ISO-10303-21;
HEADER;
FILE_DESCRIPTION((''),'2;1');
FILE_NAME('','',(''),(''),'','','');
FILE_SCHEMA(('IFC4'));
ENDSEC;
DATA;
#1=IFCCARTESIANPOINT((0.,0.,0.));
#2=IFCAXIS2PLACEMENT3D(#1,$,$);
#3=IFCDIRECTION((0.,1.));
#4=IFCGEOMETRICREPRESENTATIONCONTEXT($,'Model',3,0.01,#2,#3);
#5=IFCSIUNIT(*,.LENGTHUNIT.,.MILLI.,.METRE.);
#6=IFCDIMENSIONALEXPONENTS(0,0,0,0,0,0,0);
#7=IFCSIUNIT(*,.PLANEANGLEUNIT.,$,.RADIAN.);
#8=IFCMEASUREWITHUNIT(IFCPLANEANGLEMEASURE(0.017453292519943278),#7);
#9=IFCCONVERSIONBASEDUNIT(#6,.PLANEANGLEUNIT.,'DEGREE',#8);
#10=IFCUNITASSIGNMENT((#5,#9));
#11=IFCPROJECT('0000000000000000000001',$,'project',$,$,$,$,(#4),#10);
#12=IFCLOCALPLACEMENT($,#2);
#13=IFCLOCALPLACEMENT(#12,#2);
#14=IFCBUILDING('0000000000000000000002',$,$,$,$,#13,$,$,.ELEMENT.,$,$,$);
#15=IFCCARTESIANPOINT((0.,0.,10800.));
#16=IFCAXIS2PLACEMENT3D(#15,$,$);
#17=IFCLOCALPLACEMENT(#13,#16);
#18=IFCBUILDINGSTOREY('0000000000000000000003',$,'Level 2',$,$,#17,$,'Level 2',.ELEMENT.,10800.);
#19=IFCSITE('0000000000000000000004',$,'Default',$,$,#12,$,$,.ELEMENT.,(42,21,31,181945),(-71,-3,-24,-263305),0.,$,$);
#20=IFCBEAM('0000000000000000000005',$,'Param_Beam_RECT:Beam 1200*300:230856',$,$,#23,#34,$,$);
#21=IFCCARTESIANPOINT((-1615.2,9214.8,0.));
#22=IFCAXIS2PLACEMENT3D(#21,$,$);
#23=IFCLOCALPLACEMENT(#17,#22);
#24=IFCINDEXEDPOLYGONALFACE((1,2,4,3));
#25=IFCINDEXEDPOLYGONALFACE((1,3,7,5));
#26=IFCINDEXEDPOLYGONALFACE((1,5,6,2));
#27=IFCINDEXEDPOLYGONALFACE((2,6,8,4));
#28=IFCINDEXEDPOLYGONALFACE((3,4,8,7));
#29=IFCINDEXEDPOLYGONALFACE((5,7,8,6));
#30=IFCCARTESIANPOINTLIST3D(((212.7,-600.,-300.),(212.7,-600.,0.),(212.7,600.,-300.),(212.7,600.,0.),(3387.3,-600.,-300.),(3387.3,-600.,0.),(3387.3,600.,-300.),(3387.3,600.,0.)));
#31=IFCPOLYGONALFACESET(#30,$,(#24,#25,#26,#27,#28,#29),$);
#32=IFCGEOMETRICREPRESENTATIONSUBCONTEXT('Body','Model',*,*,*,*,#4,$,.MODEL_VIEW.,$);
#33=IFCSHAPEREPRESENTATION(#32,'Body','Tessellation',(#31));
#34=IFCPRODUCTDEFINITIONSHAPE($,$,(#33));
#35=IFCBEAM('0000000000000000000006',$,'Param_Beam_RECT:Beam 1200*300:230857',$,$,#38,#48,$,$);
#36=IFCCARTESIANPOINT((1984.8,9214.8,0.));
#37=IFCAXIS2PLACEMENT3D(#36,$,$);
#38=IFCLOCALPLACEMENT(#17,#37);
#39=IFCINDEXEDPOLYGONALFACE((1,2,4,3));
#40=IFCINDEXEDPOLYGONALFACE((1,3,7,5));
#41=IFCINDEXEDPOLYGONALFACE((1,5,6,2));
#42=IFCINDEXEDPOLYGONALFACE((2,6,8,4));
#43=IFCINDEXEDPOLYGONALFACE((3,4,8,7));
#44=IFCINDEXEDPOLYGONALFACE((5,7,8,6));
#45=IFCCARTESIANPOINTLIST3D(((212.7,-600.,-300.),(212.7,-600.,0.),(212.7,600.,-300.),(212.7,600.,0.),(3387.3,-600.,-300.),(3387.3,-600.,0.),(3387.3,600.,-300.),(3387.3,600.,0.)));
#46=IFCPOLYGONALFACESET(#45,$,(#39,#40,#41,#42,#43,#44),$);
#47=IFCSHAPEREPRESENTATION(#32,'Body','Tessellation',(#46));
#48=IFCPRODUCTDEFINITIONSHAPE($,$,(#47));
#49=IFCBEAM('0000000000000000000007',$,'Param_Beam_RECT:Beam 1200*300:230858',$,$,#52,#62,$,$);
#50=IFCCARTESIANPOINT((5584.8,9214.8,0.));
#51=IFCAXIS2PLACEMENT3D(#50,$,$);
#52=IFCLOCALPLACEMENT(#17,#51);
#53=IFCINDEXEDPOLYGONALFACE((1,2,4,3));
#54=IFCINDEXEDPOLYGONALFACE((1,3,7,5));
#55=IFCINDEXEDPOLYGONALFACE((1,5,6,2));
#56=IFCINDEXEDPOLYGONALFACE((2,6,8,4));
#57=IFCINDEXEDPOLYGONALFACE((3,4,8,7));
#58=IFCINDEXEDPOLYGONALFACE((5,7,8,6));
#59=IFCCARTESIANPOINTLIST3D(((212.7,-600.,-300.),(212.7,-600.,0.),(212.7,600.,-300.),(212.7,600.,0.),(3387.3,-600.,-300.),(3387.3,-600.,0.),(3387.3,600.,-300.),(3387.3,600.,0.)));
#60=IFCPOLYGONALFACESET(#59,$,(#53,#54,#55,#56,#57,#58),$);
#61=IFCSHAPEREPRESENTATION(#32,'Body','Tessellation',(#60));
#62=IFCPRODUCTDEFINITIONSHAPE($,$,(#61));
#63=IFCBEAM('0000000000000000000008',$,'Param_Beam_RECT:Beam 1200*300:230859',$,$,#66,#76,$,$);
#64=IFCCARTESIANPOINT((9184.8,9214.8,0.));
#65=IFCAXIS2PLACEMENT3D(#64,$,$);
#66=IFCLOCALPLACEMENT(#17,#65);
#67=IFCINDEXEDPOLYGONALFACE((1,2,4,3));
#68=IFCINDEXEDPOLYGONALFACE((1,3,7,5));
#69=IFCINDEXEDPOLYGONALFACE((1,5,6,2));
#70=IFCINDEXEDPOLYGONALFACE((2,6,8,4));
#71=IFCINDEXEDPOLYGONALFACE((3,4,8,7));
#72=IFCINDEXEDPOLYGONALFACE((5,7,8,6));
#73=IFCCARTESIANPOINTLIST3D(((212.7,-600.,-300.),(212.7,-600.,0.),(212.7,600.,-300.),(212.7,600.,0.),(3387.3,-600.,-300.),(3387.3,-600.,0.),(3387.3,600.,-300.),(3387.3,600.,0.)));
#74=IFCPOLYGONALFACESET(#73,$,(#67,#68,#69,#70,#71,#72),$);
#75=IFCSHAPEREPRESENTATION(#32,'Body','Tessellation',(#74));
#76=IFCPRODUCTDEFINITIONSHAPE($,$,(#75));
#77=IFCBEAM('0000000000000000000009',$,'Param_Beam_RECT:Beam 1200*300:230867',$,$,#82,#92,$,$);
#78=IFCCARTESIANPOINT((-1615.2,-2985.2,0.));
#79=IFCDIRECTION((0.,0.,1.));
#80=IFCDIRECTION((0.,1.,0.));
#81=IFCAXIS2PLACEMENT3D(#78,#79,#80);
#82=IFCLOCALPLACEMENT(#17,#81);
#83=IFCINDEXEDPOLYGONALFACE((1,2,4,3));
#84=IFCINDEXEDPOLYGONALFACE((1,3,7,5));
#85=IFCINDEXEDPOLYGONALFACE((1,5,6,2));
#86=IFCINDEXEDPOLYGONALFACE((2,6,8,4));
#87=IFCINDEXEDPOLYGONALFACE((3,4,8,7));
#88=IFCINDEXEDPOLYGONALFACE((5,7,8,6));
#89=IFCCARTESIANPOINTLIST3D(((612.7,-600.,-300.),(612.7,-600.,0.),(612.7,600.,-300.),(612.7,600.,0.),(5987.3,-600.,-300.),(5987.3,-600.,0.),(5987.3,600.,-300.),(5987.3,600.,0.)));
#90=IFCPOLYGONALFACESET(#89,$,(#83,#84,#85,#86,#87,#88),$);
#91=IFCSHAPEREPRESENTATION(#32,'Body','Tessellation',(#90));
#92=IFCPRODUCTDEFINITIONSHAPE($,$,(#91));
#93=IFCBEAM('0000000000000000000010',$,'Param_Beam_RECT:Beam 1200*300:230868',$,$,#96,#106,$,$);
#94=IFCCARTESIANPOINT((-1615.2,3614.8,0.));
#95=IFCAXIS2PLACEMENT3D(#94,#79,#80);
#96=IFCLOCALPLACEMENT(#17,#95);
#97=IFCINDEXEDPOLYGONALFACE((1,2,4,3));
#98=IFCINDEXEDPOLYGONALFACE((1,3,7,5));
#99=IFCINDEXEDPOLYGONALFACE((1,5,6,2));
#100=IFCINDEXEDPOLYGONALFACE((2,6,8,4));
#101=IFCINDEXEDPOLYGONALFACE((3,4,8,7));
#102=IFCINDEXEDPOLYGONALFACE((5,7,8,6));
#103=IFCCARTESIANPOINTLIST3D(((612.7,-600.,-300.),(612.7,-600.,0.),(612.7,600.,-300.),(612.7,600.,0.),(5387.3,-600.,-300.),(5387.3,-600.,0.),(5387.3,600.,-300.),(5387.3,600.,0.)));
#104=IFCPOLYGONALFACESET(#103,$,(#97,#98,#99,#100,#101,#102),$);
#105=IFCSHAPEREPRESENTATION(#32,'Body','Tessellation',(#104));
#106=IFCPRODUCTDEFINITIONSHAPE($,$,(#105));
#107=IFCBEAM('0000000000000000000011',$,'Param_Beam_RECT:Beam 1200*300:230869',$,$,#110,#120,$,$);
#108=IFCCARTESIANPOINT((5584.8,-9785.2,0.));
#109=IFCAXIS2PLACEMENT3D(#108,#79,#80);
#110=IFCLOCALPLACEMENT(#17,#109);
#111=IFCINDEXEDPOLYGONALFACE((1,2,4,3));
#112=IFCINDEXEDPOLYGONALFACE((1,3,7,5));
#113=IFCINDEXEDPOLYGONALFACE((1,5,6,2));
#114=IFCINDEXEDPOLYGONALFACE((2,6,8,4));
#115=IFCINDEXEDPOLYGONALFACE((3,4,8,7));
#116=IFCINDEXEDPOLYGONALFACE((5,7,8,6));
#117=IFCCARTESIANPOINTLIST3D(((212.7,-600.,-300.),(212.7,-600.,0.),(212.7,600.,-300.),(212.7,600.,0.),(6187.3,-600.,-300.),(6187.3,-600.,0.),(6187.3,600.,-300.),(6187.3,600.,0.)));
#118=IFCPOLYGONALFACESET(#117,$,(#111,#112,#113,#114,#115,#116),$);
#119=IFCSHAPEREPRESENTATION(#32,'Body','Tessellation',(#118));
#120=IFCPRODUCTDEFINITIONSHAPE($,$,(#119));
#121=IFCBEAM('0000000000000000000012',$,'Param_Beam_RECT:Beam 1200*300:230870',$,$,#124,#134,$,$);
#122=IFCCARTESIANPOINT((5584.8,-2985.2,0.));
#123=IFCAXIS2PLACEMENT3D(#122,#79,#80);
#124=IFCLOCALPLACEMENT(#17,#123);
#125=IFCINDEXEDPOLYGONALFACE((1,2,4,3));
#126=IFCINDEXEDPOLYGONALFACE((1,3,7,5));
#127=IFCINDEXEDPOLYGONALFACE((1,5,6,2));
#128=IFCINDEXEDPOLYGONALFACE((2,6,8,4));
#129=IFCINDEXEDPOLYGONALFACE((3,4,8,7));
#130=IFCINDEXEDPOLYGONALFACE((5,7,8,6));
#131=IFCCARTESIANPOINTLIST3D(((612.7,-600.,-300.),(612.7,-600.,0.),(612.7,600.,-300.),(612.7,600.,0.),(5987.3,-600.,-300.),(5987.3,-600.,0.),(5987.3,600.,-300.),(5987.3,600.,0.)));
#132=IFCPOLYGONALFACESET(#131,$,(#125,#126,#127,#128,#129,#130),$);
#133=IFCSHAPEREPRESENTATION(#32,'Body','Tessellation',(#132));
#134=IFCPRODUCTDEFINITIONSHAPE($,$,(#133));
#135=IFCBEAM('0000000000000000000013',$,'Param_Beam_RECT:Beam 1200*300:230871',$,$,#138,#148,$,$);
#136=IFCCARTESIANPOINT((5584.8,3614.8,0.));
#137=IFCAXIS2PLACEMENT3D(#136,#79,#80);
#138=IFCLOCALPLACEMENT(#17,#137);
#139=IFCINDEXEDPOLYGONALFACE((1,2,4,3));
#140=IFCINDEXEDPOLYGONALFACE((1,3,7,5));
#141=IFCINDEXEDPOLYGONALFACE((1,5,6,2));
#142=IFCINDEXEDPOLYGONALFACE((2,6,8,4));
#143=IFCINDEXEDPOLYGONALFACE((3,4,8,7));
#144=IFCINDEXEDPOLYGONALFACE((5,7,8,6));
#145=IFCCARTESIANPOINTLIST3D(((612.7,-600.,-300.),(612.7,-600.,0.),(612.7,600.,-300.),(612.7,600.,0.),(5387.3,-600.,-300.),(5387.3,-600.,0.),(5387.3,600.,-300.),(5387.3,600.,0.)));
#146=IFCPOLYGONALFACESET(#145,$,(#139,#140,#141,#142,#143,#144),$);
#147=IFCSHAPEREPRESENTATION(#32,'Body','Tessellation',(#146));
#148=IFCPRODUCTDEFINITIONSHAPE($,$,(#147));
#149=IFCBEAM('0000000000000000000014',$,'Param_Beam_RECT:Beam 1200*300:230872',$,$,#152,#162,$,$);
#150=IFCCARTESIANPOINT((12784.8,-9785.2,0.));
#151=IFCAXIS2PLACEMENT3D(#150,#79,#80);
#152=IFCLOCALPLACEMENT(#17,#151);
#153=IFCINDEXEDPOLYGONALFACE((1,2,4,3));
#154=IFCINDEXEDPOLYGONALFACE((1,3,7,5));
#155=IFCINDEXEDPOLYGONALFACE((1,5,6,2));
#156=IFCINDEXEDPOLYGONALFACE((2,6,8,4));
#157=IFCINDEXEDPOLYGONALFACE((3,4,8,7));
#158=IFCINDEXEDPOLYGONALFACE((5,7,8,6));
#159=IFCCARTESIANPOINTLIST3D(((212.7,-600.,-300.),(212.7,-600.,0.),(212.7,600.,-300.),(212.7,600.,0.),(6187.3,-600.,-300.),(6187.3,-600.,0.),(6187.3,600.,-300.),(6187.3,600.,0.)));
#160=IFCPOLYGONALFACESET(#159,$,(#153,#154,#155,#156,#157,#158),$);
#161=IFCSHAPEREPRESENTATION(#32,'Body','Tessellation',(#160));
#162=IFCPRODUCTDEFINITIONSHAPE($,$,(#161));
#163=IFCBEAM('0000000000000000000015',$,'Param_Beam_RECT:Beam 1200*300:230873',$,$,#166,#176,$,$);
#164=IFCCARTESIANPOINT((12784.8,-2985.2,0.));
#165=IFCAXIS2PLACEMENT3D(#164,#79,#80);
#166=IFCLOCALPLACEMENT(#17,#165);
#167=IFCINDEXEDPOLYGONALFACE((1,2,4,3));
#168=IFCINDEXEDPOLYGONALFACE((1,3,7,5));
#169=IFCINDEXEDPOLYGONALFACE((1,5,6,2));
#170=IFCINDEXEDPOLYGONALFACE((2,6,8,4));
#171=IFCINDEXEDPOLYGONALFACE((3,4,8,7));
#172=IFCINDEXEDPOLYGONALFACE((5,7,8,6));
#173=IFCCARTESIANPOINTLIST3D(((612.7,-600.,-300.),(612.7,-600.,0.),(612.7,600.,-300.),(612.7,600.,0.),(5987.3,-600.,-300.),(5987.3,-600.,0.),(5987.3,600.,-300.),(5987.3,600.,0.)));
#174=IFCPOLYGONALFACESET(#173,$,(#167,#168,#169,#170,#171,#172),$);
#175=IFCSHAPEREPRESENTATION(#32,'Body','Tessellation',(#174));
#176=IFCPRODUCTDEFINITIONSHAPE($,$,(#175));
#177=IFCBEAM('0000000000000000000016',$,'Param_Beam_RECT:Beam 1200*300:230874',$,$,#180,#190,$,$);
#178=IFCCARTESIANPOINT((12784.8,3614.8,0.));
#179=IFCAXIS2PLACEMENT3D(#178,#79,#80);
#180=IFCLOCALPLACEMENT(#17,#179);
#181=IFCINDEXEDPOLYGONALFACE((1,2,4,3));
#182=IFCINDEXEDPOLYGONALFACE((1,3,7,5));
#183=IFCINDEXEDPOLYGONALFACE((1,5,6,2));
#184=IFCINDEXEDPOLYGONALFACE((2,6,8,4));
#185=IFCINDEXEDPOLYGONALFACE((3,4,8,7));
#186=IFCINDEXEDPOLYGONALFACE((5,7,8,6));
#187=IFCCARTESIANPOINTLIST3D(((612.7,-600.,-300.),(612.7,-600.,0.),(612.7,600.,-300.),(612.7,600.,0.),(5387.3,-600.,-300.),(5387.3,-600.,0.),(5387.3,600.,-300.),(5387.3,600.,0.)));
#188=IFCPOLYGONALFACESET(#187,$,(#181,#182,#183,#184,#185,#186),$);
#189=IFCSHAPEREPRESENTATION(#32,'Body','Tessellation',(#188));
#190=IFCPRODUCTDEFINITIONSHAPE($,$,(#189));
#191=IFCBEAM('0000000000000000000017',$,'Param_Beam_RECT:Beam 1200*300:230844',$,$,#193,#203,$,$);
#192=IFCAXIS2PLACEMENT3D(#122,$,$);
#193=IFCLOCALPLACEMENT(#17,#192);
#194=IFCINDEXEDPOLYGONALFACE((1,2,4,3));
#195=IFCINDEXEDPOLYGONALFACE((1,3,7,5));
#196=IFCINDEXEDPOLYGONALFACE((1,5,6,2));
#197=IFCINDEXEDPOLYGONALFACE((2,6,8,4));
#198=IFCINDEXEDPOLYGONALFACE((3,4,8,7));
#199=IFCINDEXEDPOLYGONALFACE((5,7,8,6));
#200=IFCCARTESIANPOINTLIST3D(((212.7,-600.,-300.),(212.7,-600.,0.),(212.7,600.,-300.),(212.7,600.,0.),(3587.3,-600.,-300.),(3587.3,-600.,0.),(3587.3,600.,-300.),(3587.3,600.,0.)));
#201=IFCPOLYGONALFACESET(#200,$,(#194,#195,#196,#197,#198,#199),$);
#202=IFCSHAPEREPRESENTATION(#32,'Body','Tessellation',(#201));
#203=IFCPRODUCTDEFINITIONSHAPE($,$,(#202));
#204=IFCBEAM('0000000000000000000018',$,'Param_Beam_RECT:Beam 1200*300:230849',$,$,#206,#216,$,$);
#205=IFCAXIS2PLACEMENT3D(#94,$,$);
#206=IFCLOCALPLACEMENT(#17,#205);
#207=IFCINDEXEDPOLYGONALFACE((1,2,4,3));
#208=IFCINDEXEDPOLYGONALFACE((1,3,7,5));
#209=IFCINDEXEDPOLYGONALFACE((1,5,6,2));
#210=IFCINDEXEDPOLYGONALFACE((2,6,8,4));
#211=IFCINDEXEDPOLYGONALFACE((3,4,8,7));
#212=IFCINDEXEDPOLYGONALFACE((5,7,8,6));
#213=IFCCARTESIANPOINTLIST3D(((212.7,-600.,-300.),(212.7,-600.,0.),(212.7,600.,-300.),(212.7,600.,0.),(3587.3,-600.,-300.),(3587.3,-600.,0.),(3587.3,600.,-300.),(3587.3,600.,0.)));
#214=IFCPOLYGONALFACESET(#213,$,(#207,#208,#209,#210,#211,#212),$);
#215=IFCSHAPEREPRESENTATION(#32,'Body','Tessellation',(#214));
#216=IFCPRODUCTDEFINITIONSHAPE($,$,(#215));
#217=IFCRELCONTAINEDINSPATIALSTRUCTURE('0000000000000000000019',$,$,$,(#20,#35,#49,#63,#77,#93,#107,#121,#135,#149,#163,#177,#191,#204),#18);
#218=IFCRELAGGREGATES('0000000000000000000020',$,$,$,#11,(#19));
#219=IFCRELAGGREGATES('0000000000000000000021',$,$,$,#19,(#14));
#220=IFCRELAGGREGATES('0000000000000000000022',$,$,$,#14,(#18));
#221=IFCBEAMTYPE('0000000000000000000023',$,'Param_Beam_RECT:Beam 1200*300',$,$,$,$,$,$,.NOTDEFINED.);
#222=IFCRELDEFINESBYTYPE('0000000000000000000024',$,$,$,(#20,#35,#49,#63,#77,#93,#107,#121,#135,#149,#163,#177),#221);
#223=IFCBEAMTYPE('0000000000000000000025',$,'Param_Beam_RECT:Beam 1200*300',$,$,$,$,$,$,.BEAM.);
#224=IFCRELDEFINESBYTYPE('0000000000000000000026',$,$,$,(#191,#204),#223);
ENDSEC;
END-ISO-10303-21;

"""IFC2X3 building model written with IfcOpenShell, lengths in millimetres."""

from ifc_helpers import new_model, entity, si_unit, converted_unit, direction, frame, frame_2d, origin, origin_2d_with_axis, place, context, subcontext, project, spatial, rectangle, extrude, type_object, element, save


model = new_model("IFC2X3")

# Units and contexts
model_context = context("Model", 3, precision=0.01, world=origin(), true_north=direction((0.0, 1.0)))
body_context = subcontext(model_context, "Body", "Model", "MODEL_VIEW")
ifc_project = project(units=[si_unit("LENGTHUNIT", "METRE", prefix="MILLI"), converted_unit("PLANEANGLEUNIT", "DEGREE", entity("IfcPlaneAngleMeasure", 0.017453292519943278), si_unit("PLANEANGLEUNIT", "RADIAN"), dimensions=[0, 0, 0, 0, 0, 0, 0])], contexts=[model_context])

# Site, building, storey
site_placement = place(None, origin())
site = spatial("IfcSite", under=ifc_project, at=site_placement, Name="Default", CompositionType="ELEMENT", RefLatitude=(42, 21, 31, 181945), RefLongitude=(-71, -3, -24, -263305), RefElevation=0.0)
building_placement = place(site_placement, origin())
building = spatial("IfcBuilding", under=site, at=building_placement, CompositionType="ELEMENT")
storey_placement = place(building_placement, frame((0.0, 0.0, 10800.0)))
storey = spatial("IfcBuildingStorey", under=building, at=storey_placement, Name="Level 2", LongName="Level 2", CompositionType="ELEMENT", Elevation=10800.0)

# Beams
beam_type_1 = type_object("IfcBeamType", Name="Param_Beam_RECT:Beam 1200*300", PredefinedType="NOTDEFINED")
beam_1_placement = place(storey_placement, frame((-1615.2, 9214.8, 0.0)))
element("IfcBeam", 1, at=beam_1_placement, inside=storey, type_object=beam_type_1, Name="Param_Beam_RECT:Beam 1200*300:230856", context=body_context, shape_type="SweptSolid", body=[
    extrude(rectangle(XDim=300.0, YDim=1200.0, at=frame_2d((0.0, 0.0), x_axis=(1.0, 0.0))), frame((212.7, 0.0, -150.0), z_axis=(1.0, 0.0, 0.0), x_axis=(0.0, 0.0, -1.0)), (0.0, 0.0, 1.0), 3174.6),
])
beam_2_placement = place(storey_placement, frame((1984.8, 9214.8, 0.0)))
element("IfcBeam", 2, at=beam_2_placement, inside=storey, type_object=beam_type_1, Name="Param_Beam_RECT:Beam 1200*300:230857", context=body_context, shape_type="SweptSolid", body=[
    extrude(rectangle(XDim=300.0, YDim=1200.0, at=origin_2d_with_axis()), frame((212.7, 0.0, -150.0), z_axis=(1.0, 0.0, 0.0), x_axis=(0.0, 0.0, -1.0)), (0.0, 0.0, 1.0), 3174.6),
])
for number, where, name in (
    (3, (5584.8, 9214.8, 0.0), "Param_Beam_RECT:Beam 1200*300:230858"),
    (4, (9184.8, 9214.8, 0.0), "Param_Beam_RECT:Beam 1200*300:230859"),
):
    element("IfcBeam", number, at=place(storey_placement, frame(where)), inside=storey, type_object=beam_type_1, Name=name, context=body_context, shape_type="SweptSolid", body=[
        extrude(rectangle(XDim=300.0, YDim=1200.0, at=frame_2d((0.0, 0.0), x_axis=(1.0, 0.0))), frame((212.7, 0.0, -150.0), z_axis=(1.0, 0.0, 0.0), x_axis=(0.0, 0.0, -1.0)), (0.0, 0.0, 1.0), 3174.6),
    ])
beam_3_placement = place(storey_placement, frame((-1615.2, -2985.2, 0.0), z_axis=(0.0, 0.0, 1.0), x_axis=(0.0, 1.0, 0.0)))
element("IfcBeam", 5, at=beam_3_placement, inside=storey, type_object=beam_type_1, Name="Param_Beam_RECT:Beam 1200*300:230867", context=body_context, shape_type="SweptSolid", body=[
    extrude(rectangle(XDim=300.0, YDim=1200.0, at=frame_2d((0.0, 0.0), x_axis=(1.0, 0.0))), frame((612.7, 0.0, -150.0), z_axis=(1.0, 0.0, 0.0), x_axis=(0.0, 0.0, -1.0)), (0.0, 0.0, 1.0), 5374.6),
])
beam_4_placement = place(storey_placement, frame((-1615.2, 3614.8, 0.0), z_axis=(0.0, 0.0, 1.0), x_axis=(0.0, 1.0, 0.0)))
element("IfcBeam", 6, at=beam_4_placement, inside=storey, type_object=beam_type_1, Name="Param_Beam_RECT:Beam 1200*300:230868", context=body_context, shape_type="SweptSolid", body=[
    extrude(rectangle(XDim=300.0, YDim=1200.0, at=frame_2d((0.0, 0.0), x_axis=(1.0, 0.0))), frame((612.7, 0.0, -150.0), z_axis=(1.0, 0.0, 0.0), x_axis=(0.0, 0.0, -1.0)), (0.0, 0.0, 1.0), 4774.6),
])
beam_5_placement = place(storey_placement, frame((5584.8, -9785.2, 0.0), z_axis=(0.0, 0.0, 1.0), x_axis=(0.0, 1.0, 0.0)))
element("IfcBeam", 7, at=beam_5_placement, inside=storey, type_object=beam_type_1, Name="Param_Beam_RECT:Beam 1200*300:230869", context=body_context, shape_type="SweptSolid", body=[
    extrude(rectangle(XDim=300.0, YDim=1200.0, at=frame_2d((0.0, 0.0), x_axis=(1.0, 0.0))), frame((212.7, 0.0, -150.0), z_axis=(1.0, 0.0, 0.0), x_axis=(0.0, 0.0, -1.0)), (0.0, 0.0, 1.0), 5974.6),
])
beam_6_placement = place(storey_placement, frame((5584.8, -2985.2, 0.0), z_axis=(0.0, 0.0, 1.0), x_axis=(0.0, 1.0, 0.0)))
element("IfcBeam", 8, at=beam_6_placement, inside=storey, type_object=beam_type_1, Name="Param_Beam_RECT:Beam 1200*300:230870", context=body_context, shape_type="SweptSolid", body=[
    extrude(rectangle(XDim=300.0, YDim=1200.0, at=frame_2d((0.0, 0.0), x_axis=(1.0, 0.0))), frame((612.7, 0.0, -150.0), z_axis=(1.0, 0.0, 0.0), x_axis=(0.0, 0.0, -1.0)), (0.0, 0.0, 1.0), 5374.6),
])
beam_7_placement = place(storey_placement, frame((5584.8, 3614.8, 0.0), z_axis=(0.0, 0.0, 1.0), x_axis=(0.0, 1.0, 0.0)))
element("IfcBeam", 9, at=beam_7_placement, inside=storey, type_object=beam_type_1, Name="Param_Beam_RECT:Beam 1200*300:230871", context=body_context, shape_type="SweptSolid", body=[
    extrude(rectangle(XDim=300.0, YDim=1200.0, at=frame_2d((0.0, 0.0), x_axis=(1.0, 0.0))), frame((612.7, 0.0, -150.0), z_axis=(1.0, 0.0, 0.0), x_axis=(0.0, 0.0, -1.0)), (0.0, 0.0, 1.0), 4774.6),
])
beam_8_placement = place(storey_placement, frame((12784.8, -9785.2, 0.0), z_axis=(0.0, 0.0, 1.0), x_axis=(0.0, 1.0, 0.0)))
element("IfcBeam", 10, at=beam_8_placement, inside=storey, type_object=beam_type_1, Name="Param_Beam_RECT:Beam 1200*300:230872", context=body_context, shape_type="SweptSolid", body=[
    extrude(rectangle(XDim=300.0, YDim=1200.0, at=origin_2d_with_axis()), frame((212.7, 0.0, -150.0), z_axis=(1.0, 0.0, 0.0), x_axis=(0.0, 0.0, -1.0)), (0.0, 0.0, 1.0), 5974.6),
])
beam_9_placement = place(storey_placement, frame((12784.8, -2985.2, 0.0), z_axis=(0.0, 0.0, 1.0), x_axis=(0.0, 1.0, 0.0)))
element("IfcBeam", 11, at=beam_9_placement, inside=storey, type_object=beam_type_1, Name="Param_Beam_RECT:Beam 1200*300:230873", context=body_context, shape_type="SweptSolid", body=[
    extrude(rectangle(XDim=300.0, YDim=1200.0, at=frame_2d((0.0, 0.0), x_axis=(1.0, 0.0))), frame((612.7, 0.0, -150.0), z_axis=(1.0, 0.0, 0.0), x_axis=(0.0, 0.0, -1.0)), (0.0, 0.0, 1.0), 5374.6),
])
beam_10_placement = place(storey_placement, frame((12784.8, 3614.8, 0.0), z_axis=(0.0, 0.0, 1.0), x_axis=(0.0, 1.0, 0.0)))
element("IfcBeam", 12, at=beam_10_placement, inside=storey, type_object=beam_type_1, Name="Param_Beam_RECT:Beam 1200*300:230874", context=body_context, shape_type="SweptSolid", body=[
    extrude(rectangle(XDim=300.0, YDim=1200.0, at=origin_2d_with_axis()), frame((612.7, 0.0, -150.0), z_axis=(1.0, 0.0, 0.0), x_axis=(0.0, 0.0, -1.0)), (0.0, 0.0, 1.0), 4774.6),
])
beam_type_2 = type_object("IfcBeamType", Name="Param_Beam_RECT:Beam 1200*300", PredefinedType="BEAM")
beam_11_placement = place(storey_placement, frame((5584.8, -2985.2, 0.0)))
element("IfcBeam", 13, at=beam_11_placement, inside=storey, type_object=beam_type_2, Name="Param_Beam_RECT:Beam 1200*300:230844", context=body_context, shape_type="SweptSolid", body=[
    extrude(rectangle(XDim=300.0, YDim=1200.0, at=frame_2d((0.0, 0.0), x_axis=(1.0, 0.0))), frame((212.7, 0.0, -150.0), z_axis=(1.0, 0.0, 0.0), x_axis=(0.0, 0.0, -1.0)), (0.0, 0.0, 1.0), 3374.6),
])
beam_12_placement = place(storey_placement, frame((-1615.2, 3614.8, 0.0)))
element("IfcBeam", 14, at=beam_12_placement, inside=storey, type_object=beam_type_2, Name="Param_Beam_RECT:Beam 1200*300:230849", context=body_context, shape_type="SweptSolid", body=[
    extrude(rectangle(XDim=300.0, YDim=1200.0, at=frame_2d((0.0, 0.0), x_axis=(1.0, 0.0))), frame((212.7, 0.0, -150.0), z_axis=(1.0, 0.0, 0.0), x_axis=(0.0, 0.0, -1.0)), (0.0, 0.0, 1.0), 3374.6),
])

save(model, "model.ifc")
